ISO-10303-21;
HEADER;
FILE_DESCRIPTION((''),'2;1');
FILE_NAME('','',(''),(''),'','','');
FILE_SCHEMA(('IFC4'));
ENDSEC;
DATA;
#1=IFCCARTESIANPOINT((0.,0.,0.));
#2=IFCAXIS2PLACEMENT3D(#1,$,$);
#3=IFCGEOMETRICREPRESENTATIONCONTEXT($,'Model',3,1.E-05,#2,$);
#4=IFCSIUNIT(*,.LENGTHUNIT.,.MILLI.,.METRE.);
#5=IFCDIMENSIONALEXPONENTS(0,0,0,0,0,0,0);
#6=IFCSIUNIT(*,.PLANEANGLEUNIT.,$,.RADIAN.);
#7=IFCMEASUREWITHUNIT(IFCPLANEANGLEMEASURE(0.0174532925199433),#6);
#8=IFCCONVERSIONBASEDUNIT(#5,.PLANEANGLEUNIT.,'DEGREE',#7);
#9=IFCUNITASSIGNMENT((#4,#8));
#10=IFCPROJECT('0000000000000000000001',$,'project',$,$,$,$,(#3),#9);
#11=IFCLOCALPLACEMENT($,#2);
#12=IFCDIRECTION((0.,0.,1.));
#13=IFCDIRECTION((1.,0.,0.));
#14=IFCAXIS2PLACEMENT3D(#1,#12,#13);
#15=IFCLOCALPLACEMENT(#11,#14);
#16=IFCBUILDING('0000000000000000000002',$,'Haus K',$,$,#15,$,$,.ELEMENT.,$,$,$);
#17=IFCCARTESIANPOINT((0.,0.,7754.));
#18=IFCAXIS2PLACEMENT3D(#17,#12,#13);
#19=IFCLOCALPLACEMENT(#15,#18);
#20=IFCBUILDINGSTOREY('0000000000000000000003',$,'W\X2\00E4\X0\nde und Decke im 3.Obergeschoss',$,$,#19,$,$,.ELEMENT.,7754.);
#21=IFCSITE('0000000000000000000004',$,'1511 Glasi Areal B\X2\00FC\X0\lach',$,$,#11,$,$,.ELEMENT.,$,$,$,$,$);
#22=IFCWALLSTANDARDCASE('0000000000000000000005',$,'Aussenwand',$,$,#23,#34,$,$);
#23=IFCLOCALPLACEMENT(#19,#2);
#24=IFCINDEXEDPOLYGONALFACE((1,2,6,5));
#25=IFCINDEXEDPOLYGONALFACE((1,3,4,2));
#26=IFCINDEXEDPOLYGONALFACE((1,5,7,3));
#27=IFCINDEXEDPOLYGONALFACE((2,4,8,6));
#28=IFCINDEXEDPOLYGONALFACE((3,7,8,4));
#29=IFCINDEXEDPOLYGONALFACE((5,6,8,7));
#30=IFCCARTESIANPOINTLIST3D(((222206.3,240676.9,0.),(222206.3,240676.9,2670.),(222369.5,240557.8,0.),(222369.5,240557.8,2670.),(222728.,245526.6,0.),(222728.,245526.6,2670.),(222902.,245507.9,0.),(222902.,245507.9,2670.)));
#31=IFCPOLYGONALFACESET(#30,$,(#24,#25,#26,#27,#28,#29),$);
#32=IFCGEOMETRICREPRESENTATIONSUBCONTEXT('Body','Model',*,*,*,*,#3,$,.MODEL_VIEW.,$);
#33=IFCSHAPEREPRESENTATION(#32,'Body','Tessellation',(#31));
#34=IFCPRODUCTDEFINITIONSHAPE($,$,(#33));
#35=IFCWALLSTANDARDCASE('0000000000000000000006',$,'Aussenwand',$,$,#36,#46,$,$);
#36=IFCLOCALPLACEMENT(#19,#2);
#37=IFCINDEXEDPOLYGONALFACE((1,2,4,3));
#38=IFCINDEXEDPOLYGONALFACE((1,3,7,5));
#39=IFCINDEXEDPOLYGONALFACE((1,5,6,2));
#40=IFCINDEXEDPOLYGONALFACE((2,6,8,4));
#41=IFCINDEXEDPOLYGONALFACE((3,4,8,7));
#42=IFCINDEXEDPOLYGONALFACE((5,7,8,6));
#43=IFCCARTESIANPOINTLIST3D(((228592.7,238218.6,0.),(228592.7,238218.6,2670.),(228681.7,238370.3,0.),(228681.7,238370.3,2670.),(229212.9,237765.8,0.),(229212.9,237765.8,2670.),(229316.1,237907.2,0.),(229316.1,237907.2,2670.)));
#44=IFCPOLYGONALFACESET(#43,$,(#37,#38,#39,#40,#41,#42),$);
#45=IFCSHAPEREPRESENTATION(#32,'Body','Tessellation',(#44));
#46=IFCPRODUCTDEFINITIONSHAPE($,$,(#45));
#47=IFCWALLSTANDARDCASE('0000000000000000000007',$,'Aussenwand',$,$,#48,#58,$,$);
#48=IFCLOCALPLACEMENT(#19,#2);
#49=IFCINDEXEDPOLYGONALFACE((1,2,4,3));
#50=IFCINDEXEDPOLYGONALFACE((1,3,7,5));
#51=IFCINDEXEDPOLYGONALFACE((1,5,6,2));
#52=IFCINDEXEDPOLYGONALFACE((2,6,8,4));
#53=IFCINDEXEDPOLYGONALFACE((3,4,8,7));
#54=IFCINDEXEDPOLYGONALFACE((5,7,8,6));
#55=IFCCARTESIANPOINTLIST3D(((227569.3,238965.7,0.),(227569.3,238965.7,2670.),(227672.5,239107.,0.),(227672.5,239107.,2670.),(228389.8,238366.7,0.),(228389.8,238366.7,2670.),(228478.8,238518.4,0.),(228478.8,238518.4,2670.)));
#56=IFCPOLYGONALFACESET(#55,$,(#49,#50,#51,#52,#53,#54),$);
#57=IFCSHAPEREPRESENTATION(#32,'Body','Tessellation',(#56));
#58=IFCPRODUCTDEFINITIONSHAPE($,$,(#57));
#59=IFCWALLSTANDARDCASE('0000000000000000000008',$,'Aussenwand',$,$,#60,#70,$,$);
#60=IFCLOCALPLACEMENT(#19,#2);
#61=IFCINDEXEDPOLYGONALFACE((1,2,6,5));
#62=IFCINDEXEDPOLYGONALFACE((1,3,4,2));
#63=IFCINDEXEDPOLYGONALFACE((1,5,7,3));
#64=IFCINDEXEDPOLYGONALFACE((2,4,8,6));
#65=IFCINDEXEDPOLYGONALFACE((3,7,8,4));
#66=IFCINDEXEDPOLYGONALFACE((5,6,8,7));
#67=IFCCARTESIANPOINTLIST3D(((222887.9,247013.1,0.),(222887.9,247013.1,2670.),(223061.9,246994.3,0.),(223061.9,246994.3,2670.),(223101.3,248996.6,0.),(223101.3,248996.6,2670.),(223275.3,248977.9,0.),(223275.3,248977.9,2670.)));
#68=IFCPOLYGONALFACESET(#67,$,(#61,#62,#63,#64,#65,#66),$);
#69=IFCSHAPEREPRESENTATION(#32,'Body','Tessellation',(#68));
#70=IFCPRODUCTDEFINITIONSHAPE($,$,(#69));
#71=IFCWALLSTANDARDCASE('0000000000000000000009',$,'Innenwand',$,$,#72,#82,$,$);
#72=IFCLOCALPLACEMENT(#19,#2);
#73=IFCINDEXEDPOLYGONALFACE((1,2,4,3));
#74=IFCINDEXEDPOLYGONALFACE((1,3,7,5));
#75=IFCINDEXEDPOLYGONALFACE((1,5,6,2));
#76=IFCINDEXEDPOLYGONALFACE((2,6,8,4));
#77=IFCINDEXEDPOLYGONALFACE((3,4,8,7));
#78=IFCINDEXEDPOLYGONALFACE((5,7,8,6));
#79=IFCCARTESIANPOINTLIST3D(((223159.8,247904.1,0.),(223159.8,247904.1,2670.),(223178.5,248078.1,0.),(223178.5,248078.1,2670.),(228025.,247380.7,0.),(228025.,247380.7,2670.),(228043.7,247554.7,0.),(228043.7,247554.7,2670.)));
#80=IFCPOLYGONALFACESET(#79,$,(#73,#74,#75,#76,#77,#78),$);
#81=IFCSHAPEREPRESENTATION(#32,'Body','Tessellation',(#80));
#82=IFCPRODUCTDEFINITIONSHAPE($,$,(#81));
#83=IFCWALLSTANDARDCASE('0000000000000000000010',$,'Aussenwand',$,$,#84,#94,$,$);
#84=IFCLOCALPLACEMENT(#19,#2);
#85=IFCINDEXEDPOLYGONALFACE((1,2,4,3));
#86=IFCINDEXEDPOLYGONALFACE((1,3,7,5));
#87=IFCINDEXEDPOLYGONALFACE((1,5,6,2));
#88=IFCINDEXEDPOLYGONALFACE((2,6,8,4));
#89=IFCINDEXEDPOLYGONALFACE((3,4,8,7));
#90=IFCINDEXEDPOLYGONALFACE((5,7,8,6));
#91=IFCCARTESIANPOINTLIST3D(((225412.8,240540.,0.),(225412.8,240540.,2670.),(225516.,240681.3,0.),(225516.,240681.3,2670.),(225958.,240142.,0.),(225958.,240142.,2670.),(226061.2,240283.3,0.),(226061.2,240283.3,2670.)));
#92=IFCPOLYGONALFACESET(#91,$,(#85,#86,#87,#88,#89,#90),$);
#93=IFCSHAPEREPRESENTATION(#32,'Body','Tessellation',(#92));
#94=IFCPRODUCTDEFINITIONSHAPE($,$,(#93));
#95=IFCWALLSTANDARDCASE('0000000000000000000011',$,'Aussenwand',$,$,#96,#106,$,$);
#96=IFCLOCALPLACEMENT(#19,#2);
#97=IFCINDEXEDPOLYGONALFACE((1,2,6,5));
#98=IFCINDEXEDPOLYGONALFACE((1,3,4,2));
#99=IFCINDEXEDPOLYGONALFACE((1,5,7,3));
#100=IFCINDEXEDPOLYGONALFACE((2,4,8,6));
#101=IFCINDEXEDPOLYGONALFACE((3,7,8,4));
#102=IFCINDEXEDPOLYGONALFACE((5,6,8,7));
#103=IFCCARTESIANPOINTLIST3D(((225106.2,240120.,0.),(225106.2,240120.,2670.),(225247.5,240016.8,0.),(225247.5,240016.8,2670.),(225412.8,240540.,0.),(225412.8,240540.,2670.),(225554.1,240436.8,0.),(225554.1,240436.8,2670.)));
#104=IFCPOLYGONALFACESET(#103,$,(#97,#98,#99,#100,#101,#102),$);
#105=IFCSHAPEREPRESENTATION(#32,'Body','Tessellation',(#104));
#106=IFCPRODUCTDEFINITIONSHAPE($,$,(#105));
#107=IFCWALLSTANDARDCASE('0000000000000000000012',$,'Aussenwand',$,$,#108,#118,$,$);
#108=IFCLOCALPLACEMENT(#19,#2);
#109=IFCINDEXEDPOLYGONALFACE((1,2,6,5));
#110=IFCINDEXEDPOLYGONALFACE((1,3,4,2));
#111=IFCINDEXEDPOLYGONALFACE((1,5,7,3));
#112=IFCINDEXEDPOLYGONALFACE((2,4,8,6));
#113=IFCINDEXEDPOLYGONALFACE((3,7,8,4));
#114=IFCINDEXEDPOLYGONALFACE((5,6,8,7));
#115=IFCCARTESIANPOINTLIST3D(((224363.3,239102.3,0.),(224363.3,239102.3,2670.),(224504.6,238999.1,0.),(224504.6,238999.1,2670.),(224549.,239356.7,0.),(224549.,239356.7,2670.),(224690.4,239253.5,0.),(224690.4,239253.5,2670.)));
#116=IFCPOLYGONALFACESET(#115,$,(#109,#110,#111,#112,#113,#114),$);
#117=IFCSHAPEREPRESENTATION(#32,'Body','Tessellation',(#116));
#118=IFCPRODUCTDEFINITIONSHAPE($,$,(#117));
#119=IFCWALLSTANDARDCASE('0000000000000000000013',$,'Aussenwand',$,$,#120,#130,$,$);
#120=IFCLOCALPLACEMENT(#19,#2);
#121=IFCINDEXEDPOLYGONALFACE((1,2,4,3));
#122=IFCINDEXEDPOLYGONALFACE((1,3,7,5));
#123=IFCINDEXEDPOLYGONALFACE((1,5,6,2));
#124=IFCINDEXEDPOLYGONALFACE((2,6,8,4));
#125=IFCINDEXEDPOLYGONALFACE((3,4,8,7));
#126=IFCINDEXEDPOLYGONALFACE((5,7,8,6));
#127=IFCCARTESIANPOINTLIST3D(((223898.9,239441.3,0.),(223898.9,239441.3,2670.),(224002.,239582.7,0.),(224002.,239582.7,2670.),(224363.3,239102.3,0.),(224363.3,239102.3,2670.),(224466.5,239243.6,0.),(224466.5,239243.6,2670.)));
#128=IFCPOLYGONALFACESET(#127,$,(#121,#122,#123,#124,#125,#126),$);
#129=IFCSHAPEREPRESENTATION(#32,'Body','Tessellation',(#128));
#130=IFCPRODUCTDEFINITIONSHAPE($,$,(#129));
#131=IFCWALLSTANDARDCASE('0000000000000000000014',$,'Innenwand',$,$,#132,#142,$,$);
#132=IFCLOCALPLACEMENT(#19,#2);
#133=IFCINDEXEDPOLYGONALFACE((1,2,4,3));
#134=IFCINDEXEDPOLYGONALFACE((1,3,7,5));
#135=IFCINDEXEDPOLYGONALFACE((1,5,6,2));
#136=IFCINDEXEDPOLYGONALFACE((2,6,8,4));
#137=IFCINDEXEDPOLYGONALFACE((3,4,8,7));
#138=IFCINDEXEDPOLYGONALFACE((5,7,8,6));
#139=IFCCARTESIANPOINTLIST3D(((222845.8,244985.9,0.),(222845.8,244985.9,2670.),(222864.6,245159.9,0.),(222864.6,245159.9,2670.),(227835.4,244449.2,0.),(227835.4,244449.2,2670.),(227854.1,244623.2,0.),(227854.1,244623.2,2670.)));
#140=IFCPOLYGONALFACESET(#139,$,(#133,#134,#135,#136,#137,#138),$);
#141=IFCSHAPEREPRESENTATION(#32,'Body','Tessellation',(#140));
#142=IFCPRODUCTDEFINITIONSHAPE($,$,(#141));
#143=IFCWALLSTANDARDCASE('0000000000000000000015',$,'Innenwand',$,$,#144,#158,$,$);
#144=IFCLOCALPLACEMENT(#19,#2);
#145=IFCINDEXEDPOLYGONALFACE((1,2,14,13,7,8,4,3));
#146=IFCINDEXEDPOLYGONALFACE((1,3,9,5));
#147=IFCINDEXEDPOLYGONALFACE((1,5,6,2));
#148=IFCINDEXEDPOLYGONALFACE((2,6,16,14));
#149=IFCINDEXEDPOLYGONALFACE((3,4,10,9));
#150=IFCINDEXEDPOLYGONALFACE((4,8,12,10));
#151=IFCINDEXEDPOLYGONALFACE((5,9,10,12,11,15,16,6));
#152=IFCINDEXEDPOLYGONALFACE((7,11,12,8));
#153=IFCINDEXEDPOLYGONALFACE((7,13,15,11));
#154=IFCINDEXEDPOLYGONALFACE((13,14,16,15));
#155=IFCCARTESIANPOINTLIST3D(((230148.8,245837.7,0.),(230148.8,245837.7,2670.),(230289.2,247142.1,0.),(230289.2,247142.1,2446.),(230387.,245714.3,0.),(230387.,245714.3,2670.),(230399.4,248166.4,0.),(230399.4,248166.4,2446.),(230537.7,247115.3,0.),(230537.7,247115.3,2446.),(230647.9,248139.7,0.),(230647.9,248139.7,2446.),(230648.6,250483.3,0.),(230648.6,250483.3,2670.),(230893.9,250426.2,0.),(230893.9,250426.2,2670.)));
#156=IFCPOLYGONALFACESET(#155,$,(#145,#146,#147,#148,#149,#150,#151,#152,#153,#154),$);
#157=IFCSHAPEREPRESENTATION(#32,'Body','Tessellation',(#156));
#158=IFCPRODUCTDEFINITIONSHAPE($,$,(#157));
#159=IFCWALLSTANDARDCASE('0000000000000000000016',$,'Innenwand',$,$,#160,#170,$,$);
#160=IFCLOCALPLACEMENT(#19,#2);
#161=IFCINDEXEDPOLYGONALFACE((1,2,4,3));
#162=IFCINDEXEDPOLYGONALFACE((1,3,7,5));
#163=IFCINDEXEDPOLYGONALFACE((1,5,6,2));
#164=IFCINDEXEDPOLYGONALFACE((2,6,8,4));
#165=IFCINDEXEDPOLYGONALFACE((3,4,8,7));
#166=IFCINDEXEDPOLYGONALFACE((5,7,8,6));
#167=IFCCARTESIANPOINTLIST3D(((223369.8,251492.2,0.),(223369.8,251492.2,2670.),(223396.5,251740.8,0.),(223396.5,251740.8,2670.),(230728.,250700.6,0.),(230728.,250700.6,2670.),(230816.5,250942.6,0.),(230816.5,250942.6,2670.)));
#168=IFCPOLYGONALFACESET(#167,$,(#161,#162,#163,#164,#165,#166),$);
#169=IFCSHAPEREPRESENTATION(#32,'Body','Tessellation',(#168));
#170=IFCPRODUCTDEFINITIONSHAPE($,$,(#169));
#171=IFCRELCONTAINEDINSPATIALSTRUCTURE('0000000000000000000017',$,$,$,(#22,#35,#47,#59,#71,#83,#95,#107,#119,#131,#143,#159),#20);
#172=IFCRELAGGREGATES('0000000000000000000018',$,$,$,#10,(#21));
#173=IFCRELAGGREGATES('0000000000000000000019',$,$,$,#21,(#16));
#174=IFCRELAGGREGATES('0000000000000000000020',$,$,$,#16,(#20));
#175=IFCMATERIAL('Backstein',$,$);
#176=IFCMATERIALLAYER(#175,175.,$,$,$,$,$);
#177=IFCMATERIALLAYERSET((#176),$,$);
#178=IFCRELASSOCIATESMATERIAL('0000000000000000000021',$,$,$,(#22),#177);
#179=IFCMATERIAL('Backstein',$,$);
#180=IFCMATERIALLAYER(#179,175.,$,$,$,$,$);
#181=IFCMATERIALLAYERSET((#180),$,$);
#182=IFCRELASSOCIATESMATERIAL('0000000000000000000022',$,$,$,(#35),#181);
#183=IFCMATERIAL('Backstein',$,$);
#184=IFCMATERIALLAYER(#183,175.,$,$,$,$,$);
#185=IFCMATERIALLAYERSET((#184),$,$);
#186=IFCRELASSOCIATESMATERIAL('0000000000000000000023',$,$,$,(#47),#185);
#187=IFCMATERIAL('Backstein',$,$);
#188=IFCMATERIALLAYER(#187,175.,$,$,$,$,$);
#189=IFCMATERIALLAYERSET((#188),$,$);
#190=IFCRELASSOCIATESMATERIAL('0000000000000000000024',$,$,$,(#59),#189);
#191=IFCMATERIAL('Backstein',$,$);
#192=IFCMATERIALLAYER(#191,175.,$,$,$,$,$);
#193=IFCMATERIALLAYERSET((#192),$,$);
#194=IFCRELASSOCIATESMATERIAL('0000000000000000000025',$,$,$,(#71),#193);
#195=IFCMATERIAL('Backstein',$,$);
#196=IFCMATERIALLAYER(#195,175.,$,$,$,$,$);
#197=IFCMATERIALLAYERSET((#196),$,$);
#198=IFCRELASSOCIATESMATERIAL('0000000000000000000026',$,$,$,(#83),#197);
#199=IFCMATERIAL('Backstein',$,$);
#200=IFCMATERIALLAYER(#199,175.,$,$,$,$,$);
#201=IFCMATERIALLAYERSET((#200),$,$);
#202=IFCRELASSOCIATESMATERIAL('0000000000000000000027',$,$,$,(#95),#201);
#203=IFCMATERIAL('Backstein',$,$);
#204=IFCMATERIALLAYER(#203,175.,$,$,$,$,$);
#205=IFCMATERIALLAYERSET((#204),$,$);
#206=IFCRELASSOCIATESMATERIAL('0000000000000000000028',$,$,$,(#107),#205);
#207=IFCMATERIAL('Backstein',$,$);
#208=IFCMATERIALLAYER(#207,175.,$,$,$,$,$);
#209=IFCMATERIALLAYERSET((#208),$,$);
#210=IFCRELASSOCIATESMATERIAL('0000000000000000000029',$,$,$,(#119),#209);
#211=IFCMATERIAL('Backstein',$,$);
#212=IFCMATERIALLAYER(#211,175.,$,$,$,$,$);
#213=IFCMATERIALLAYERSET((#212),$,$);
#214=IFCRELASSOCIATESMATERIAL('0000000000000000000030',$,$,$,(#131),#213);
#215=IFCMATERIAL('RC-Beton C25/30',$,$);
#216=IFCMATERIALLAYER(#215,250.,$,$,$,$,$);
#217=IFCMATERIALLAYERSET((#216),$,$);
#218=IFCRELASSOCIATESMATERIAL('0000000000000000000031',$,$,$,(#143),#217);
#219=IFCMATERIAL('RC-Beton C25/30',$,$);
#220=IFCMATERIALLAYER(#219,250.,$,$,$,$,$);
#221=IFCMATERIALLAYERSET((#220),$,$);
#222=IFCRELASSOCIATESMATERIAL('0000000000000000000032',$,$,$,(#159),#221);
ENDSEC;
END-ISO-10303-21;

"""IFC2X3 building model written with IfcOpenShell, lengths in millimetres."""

from ifc_helpers import new_model, entity, si_unit, converted_unit, frame, frame_2d, origin, origin_with_axes, place, context, subcontext, project, spatial, polyline, rectangle, outline, extrude, material, layer, layer_set, layer_usage, element, save


model = new_model("IFC2X3")

# Units and contexts
model_context = context("Model", 3, precision=1e-05, world=origin())
body_context = subcontext(model_context, "Body", "Model", "MODEL_VIEW")
ifc_project = project(units=[si_unit("LENGTHUNIT", "METRE", prefix="MILLI"), converted_unit("PLANEANGLEUNIT", "DEGREE", entity("IfcPlaneAngleMeasure", 0.0174532925199433), si_unit("PLANEANGLEUNIT", "RADIAN"), dimensions=[0, 0, 0, 0, 0, 0, 0])], contexts=[model_context])

# Site, building, storey
site_placement = place(None, origin())
site = spatial("IfcSite", under=ifc_project, at=site_placement, Name="1511 Glasi Areal Bülach", CompositionType="ELEMENT")
building_placement = place(site_placement, origin_with_axes())
building = spatial("IfcBuilding", under=site, at=building_placement, Name="Haus K", CompositionType="ELEMENT")
storey_placement = place(building_placement, frame((0.0, 0.0, 7754.0), z_axis=(0.0, 0.0, 1.0), x_axis=(1.0, 0.0, 0.0)))
storey = spatial("IfcBuildingStorey", under=building, at=storey_placement, Name="Wände und Decke im 3.Obergeschoss", CompositionType="ELEMENT", Elevation=7754.0)

# Walls
ifc_material_1 = material(Name="Backstein")
ifc_layer_1 = layer(ifc_material_1, 175.0)
ifc_layer_set_1 = layer_set([ifc_layer_1])
ifc_layer_usage_1 = layer_usage(ifc_layer_set_1, "AXIS2", "POSITIVE", 0.0)
wall_1_placement = place(storey_placement, frame((222728.0, 245526.6, 0.0), z_axis=(0.0, 0.0, 1.0), x_axis=(-0.106958, -0.994264, 0.0)))
element("IfcWallStandardCase", 1, at=wall_1_placement, inside=storey, material=ifc_layer_usage_1, Name="Aussenwand", context=body_context, shape_type="SweptSolid", body=[
    extrude(outline(polyline([(0.0, 0.0), (4877.7, 0.0), (4978.7, 175.0), (0.0, 175.0), (0.0, 0.0)])), origin_with_axes(), (0.0, 0.0, 1.0), 2670.0),
])
ifc_material_2 = material(Name="Backstein")
ifc_layer_2 = layer(ifc_material_2, 175.0)
ifc_layer_set_2 = layer_set([ifc_layer_2])
ifc_layer_usage_2 = layer_usage(ifc_layer_set_2, "AXIS2", "POSITIVE", 0.0)
wall_2_placement = place(storey_placement, frame((228592.7, 238218.6, 0.0), z_axis=(0.0, 0.0, 1.0), x_axis=(0.807681, -0.589619, 0.0)))
element("IfcWallStandardCase", 2, at=wall_2_placement, inside=storey, material=ifc_layer_usage_2, Name="Aussenwand", context=body_context, shape_type="SweptSolid", body=[
    extrude(outline(polyline([(0.0, 0.0), (767.9, 0.0), (767.9, 175.0), (-17.6, 175.0), (0.0, 0.0)])), origin_with_axes(), (0.0, 0.0, 1.0), 2670.0),
])
ifc_material_3 = material(Name="Backstein")
ifc_layer_3 = layer(ifc_material_3, 175.0)
ifc_layer_set_3 = layer_set([ifc_layer_3])
ifc_layer_usage_3 = layer_usage(ifc_layer_set_3, "AXIS2", "POSITIVE", 0.0)
wall_3_placement = place(storey_placement, frame((227569.3, 238965.7, 0.0), z_axis=(0.0, 0.0, 1.0), x_axis=(0.807681, -0.589619, 0.0)))
element("IfcWallStandardCase", 3, at=wall_3_placement, inside=storey, material=ifc_layer_usage_3, Name="Aussenwand", context=body_context, shape_type="SweptSolid", body=[
    extrude(outline(polyline([(0.0, 0.0), (1015.8, 0.0), (998.3, 175.0), (0.0, 175.0), (0.0, 0.0)])), origin_with_axes(), (0.0, 0.0, 1.0), 2670.0),
])
ifc_material_4 = material(Name="Backstein")
ifc_layer_4 = layer(ifc_material_4, 175.0)
ifc_layer_set_4 = layer_set([ifc_layer_4])
ifc_layer_usage_4 = layer_usage(ifc_layer_set_4, "AXIS2", "POSITIVE", 0.0)
wall_4_placement = place(storey_placement, frame((223101.3, 248996.6, 0.0), z_axis=(0.0, 0.0, 1.0), x_axis=(-0.106958, -0.994264, 0.0)))
element("IfcWallStandardCase", 4, at=wall_4_placement, inside=storey, material=ifc_layer_usage_4, Name="Aussenwand", context=body_context, shape_type="SweptSolid", body=[
    extrude(rectangle(XDim=1995.0, YDim=175.0, at=frame_2d((997.5, 87.5), x_axis=(1.0, 0.0))), origin_with_axes(), (0.0, 0.0, 1.0), 2670.0),
])
ifc_material_5 = material(Name="Backstein")
ifc_layer_5 = layer(ifc_material_5, 175.0)
ifc_layer_set_5 = layer_set([ifc_layer_5])
ifc_layer_usage_5 = layer_usage(ifc_layer_set_5, "AXIS2", "POSITIVE", 0.0)
wall_5_placement = place(storey_placement, frame((223159.8, 247904.1, 0.0), z_axis=(0.0, 0.0, 1.0), x_axis=(0.994264, -0.106958, 0.0)))
element("IfcWallStandardCase", 5, at=wall_5_placement, inside=storey, material=ifc_layer_usage_5, Name="Innenwand", context=body_context, shape_type="SweptSolid", body=[
    extrude(rectangle(XDim=4893.3, YDim=175.0, at=frame_2d((2446.7, 87.5), x_axis=(1.0, 0.0))), origin_with_axes(), (0.0, 0.0, 1.0), 2670.0),
])
ifc_material_6 = material(Name="Backstein")
ifc_layer_6 = layer(ifc_material_6, 175.0)
ifc_layer_set_6 = layer_set([ifc_layer_6])
ifc_layer_usage_6 = layer_usage(ifc_layer_set_6, "AXIS2", "POSITIVE", 0.0)
wall_6_placement = place(storey_placement, frame((225412.8, 240540.0, 0.0), z_axis=(0.0, 0.0, 1.0), x_axis=(0.807681, -0.589619, 0.0)))
element("IfcWallStandardCase", 6, at=wall_6_placement, inside=storey, material=ifc_layer_usage_6, Name="Aussenwand", context=body_context, shape_type="SweptSolid", body=[
    extrude(rectangle(XDim=675.0, YDim=175.0, at=frame_2d((337.5, 87.5), x_axis=(1.0, 0.0))), origin_with_axes(), (0.0, 0.0, 1.0), 2670.0),
])
ifc_material_7 = material(Name="Backstein")
ifc_layer_7 = layer(ifc_material_7, 175.0)
ifc_layer_set_7 = layer_set([ifc_layer_7])
ifc_layer_usage_7 = layer_usage(ifc_layer_set_7, "AXIS2", "POSITIVE", 0.0)
wall_7_placement = place(storey_placement, frame((225247.5, 240016.8, 0.0), z_axis=(0.0, 0.0, 1.0), x_axis=(0.589619, 0.807681, 0.0)))
element("IfcWallStandardCase", 7, at=wall_7_placement, inside=storey, material=ifc_layer_usage_7, Name="Aussenwand", context=body_context, shape_type="SweptSolid", body=[
    extrude(rectangle(XDim=520.0, YDim=175.0, at=frame_2d((260.0, 87.5), x_axis=(1.0, 0.0))), origin_with_axes(), (0.0, 0.0, 1.0), 2670.0),
])
ifc_material_8 = material(Name="Backstein")
ifc_layer_8 = layer(ifc_material_8, 175.0)
ifc_layer_set_8 = layer_set([ifc_layer_8])
ifc_layer_usage_8 = layer_usage(ifc_layer_set_8, "AXIS2", "POSITIVE", 0.0)
wall_8_placement = place(storey_placement, frame((224504.6, 238999.1, 0.0), z_axis=(0.0, 0.0, 1.0), x_axis=(0.589619, 0.807681, 0.0)))
element("IfcWallStandardCase", 8, at=wall_8_placement, inside=storey, material=ifc_layer_usage_8, Name="Aussenwand", context=body_context, shape_type="SweptSolid", body=[
    extrude(rectangle(XDim=315.0, YDim=175.0, at=frame_2d((157.5, 87.5), x_axis=(1.0, 0.0))), origin_with_axes(), (0.0, 0.0, 1.0), 2670.0),
])
ifc_material_9 = material(Name="Backstein")
ifc_layer_9 = layer(ifc_material_9, 175.0)
ifc_layer_set_9 = layer_set([ifc_layer_9])
ifc_layer_usage_9 = layer_usage(ifc_layer_set_9, "AXIS2", "POSITIVE", 0.0)
wall_9_placement = place(storey_placement, frame((223898.9, 239441.3, 0.0), z_axis=(0.0, 0.0, 1.0), x_axis=(0.807681, -0.589619, 0.0)))
element("IfcWallStandardCase", 9, at=wall_9_placement, inside=storey, material=ifc_layer_usage_9, Name="Aussenwand", context=body_context, shape_type="SweptSolid", body=[
    extrude(rectangle(XDim=575.0, YDim=175.0, at=frame_2d((287.5, 87.5), x_axis=(1.0, 0.0))), origin_with_axes(), (0.0, 0.0, 1.0), 2670.0),
])
ifc_material_10 = material(Name="Backstein")
ifc_layer_10 = layer(ifc_material_10, 175.0)
ifc_layer_set_10 = layer_set([ifc_layer_10])
ifc_layer_usage_10 = layer_usage(ifc_layer_set_10, "AXIS2", "POSITIVE", 0.0)
wall_10_placement = place(storey_placement, frame((222845.8, 244985.9, 0.0), z_axis=(0.0, 0.0, 1.0), x_axis=(0.994264, -0.106958, 0.0)))
element("IfcWallStandardCase", 10, at=wall_10_placement, inside=storey, material=ifc_layer_usage_10, Name="Innenwand", context=body_context, shape_type="SweptSolid", body=[
    extrude(rectangle(XDim=5018.3, YDim=175.0, at=frame_2d((2509.2, 87.5), x_axis=(1.0, 0.0))), origin_with_axes(), (0.0, 0.0, 1.0), 2670.0),
])

# Wall, opening
ifc_material_11 = material(Name="RC-Beton C25/30")
ifc_layer_11 = layer(ifc_material_11, 250.0)
ifc_layer_set_11 = layer_set([ifc_layer_11])
ifc_layer_usage_11 = layer_usage(ifc_layer_set_11, "AXIS2", "POSITIVE", 0.0)
wall_11_placement = place(storey_placement, frame((230387.0, 245714.3, 0.0), z_axis=(0.0, 0.0, 1.0), x_axis=(0.106958, 0.994264, 0.0)))
wall_11 = element("IfcWallStandardCase", 11, at=wall_11_placement, inside=storey, material=ifc_layer_usage_11, Name="Innenwand", context=body_context, shape_type="SweptSolid", body=[
    extrude(outline(polyline([(0.0, 0.0), (4739.1, 0.0), (4769.7, 250.0), (97.3, 250.0), (0.0, 0.0)])), origin_with_axes(), (0.0, 0.0, 1.0), 2670.0),
])
opening_1_placement = place(wall_11_placement, frame((1409.1, 0.0, 0.0), z_axis=(0.0, 1.0, 0.0), x_axis=(0.0, 0.0, 1.0)))
element("IfcOpeningElement", 12, at=opening_1_placement, cuts=wall_11, ObjectType="Opening", context=body_context, shape_type="SweptSolid", body=[
    extrude(rectangle(XDim=2446.0, YDim=1030.3, at=frame_2d((1223.0, 515.1), x_axis=(1.0, 0.0))), origin_with_axes(), (0.0, 0.0, 1.0), 250.0),
])

# Wall
ifc_material_12 = material(Name="RC-Beton C25/30")
ifc_layer_12 = layer(ifc_material_12, 250.0)
ifc_layer_set_12 = layer_set([ifc_layer_12])
ifc_layer_usage_12 = layer_usage(ifc_layer_set_12, "AXIS2", "POSITIVE", 0.0)
wall_12_placement = place(storey_placement, frame((230816.5, 250942.6, 0.0), z_axis=(0.0, 0.0, 1.0), x_axis=(-0.994264, 0.106958, 0.0)))
element("IfcWallStandardCase", 13, at=wall_12_placement, inside=storey, material=ifc_layer_usage_12, Name="Innenwand", context=body_context, shape_type="SweptSolid", body=[
    extrude(outline(polyline([(0.0, 0.0), (7462.8, 0.0), (7462.8, 250.0), (62.1, 250.0), (0.0, 0.0)])), origin_with_axes(), (0.0, 0.0, 1.0), 2670.0),
])

save(model, "model.ifc")
